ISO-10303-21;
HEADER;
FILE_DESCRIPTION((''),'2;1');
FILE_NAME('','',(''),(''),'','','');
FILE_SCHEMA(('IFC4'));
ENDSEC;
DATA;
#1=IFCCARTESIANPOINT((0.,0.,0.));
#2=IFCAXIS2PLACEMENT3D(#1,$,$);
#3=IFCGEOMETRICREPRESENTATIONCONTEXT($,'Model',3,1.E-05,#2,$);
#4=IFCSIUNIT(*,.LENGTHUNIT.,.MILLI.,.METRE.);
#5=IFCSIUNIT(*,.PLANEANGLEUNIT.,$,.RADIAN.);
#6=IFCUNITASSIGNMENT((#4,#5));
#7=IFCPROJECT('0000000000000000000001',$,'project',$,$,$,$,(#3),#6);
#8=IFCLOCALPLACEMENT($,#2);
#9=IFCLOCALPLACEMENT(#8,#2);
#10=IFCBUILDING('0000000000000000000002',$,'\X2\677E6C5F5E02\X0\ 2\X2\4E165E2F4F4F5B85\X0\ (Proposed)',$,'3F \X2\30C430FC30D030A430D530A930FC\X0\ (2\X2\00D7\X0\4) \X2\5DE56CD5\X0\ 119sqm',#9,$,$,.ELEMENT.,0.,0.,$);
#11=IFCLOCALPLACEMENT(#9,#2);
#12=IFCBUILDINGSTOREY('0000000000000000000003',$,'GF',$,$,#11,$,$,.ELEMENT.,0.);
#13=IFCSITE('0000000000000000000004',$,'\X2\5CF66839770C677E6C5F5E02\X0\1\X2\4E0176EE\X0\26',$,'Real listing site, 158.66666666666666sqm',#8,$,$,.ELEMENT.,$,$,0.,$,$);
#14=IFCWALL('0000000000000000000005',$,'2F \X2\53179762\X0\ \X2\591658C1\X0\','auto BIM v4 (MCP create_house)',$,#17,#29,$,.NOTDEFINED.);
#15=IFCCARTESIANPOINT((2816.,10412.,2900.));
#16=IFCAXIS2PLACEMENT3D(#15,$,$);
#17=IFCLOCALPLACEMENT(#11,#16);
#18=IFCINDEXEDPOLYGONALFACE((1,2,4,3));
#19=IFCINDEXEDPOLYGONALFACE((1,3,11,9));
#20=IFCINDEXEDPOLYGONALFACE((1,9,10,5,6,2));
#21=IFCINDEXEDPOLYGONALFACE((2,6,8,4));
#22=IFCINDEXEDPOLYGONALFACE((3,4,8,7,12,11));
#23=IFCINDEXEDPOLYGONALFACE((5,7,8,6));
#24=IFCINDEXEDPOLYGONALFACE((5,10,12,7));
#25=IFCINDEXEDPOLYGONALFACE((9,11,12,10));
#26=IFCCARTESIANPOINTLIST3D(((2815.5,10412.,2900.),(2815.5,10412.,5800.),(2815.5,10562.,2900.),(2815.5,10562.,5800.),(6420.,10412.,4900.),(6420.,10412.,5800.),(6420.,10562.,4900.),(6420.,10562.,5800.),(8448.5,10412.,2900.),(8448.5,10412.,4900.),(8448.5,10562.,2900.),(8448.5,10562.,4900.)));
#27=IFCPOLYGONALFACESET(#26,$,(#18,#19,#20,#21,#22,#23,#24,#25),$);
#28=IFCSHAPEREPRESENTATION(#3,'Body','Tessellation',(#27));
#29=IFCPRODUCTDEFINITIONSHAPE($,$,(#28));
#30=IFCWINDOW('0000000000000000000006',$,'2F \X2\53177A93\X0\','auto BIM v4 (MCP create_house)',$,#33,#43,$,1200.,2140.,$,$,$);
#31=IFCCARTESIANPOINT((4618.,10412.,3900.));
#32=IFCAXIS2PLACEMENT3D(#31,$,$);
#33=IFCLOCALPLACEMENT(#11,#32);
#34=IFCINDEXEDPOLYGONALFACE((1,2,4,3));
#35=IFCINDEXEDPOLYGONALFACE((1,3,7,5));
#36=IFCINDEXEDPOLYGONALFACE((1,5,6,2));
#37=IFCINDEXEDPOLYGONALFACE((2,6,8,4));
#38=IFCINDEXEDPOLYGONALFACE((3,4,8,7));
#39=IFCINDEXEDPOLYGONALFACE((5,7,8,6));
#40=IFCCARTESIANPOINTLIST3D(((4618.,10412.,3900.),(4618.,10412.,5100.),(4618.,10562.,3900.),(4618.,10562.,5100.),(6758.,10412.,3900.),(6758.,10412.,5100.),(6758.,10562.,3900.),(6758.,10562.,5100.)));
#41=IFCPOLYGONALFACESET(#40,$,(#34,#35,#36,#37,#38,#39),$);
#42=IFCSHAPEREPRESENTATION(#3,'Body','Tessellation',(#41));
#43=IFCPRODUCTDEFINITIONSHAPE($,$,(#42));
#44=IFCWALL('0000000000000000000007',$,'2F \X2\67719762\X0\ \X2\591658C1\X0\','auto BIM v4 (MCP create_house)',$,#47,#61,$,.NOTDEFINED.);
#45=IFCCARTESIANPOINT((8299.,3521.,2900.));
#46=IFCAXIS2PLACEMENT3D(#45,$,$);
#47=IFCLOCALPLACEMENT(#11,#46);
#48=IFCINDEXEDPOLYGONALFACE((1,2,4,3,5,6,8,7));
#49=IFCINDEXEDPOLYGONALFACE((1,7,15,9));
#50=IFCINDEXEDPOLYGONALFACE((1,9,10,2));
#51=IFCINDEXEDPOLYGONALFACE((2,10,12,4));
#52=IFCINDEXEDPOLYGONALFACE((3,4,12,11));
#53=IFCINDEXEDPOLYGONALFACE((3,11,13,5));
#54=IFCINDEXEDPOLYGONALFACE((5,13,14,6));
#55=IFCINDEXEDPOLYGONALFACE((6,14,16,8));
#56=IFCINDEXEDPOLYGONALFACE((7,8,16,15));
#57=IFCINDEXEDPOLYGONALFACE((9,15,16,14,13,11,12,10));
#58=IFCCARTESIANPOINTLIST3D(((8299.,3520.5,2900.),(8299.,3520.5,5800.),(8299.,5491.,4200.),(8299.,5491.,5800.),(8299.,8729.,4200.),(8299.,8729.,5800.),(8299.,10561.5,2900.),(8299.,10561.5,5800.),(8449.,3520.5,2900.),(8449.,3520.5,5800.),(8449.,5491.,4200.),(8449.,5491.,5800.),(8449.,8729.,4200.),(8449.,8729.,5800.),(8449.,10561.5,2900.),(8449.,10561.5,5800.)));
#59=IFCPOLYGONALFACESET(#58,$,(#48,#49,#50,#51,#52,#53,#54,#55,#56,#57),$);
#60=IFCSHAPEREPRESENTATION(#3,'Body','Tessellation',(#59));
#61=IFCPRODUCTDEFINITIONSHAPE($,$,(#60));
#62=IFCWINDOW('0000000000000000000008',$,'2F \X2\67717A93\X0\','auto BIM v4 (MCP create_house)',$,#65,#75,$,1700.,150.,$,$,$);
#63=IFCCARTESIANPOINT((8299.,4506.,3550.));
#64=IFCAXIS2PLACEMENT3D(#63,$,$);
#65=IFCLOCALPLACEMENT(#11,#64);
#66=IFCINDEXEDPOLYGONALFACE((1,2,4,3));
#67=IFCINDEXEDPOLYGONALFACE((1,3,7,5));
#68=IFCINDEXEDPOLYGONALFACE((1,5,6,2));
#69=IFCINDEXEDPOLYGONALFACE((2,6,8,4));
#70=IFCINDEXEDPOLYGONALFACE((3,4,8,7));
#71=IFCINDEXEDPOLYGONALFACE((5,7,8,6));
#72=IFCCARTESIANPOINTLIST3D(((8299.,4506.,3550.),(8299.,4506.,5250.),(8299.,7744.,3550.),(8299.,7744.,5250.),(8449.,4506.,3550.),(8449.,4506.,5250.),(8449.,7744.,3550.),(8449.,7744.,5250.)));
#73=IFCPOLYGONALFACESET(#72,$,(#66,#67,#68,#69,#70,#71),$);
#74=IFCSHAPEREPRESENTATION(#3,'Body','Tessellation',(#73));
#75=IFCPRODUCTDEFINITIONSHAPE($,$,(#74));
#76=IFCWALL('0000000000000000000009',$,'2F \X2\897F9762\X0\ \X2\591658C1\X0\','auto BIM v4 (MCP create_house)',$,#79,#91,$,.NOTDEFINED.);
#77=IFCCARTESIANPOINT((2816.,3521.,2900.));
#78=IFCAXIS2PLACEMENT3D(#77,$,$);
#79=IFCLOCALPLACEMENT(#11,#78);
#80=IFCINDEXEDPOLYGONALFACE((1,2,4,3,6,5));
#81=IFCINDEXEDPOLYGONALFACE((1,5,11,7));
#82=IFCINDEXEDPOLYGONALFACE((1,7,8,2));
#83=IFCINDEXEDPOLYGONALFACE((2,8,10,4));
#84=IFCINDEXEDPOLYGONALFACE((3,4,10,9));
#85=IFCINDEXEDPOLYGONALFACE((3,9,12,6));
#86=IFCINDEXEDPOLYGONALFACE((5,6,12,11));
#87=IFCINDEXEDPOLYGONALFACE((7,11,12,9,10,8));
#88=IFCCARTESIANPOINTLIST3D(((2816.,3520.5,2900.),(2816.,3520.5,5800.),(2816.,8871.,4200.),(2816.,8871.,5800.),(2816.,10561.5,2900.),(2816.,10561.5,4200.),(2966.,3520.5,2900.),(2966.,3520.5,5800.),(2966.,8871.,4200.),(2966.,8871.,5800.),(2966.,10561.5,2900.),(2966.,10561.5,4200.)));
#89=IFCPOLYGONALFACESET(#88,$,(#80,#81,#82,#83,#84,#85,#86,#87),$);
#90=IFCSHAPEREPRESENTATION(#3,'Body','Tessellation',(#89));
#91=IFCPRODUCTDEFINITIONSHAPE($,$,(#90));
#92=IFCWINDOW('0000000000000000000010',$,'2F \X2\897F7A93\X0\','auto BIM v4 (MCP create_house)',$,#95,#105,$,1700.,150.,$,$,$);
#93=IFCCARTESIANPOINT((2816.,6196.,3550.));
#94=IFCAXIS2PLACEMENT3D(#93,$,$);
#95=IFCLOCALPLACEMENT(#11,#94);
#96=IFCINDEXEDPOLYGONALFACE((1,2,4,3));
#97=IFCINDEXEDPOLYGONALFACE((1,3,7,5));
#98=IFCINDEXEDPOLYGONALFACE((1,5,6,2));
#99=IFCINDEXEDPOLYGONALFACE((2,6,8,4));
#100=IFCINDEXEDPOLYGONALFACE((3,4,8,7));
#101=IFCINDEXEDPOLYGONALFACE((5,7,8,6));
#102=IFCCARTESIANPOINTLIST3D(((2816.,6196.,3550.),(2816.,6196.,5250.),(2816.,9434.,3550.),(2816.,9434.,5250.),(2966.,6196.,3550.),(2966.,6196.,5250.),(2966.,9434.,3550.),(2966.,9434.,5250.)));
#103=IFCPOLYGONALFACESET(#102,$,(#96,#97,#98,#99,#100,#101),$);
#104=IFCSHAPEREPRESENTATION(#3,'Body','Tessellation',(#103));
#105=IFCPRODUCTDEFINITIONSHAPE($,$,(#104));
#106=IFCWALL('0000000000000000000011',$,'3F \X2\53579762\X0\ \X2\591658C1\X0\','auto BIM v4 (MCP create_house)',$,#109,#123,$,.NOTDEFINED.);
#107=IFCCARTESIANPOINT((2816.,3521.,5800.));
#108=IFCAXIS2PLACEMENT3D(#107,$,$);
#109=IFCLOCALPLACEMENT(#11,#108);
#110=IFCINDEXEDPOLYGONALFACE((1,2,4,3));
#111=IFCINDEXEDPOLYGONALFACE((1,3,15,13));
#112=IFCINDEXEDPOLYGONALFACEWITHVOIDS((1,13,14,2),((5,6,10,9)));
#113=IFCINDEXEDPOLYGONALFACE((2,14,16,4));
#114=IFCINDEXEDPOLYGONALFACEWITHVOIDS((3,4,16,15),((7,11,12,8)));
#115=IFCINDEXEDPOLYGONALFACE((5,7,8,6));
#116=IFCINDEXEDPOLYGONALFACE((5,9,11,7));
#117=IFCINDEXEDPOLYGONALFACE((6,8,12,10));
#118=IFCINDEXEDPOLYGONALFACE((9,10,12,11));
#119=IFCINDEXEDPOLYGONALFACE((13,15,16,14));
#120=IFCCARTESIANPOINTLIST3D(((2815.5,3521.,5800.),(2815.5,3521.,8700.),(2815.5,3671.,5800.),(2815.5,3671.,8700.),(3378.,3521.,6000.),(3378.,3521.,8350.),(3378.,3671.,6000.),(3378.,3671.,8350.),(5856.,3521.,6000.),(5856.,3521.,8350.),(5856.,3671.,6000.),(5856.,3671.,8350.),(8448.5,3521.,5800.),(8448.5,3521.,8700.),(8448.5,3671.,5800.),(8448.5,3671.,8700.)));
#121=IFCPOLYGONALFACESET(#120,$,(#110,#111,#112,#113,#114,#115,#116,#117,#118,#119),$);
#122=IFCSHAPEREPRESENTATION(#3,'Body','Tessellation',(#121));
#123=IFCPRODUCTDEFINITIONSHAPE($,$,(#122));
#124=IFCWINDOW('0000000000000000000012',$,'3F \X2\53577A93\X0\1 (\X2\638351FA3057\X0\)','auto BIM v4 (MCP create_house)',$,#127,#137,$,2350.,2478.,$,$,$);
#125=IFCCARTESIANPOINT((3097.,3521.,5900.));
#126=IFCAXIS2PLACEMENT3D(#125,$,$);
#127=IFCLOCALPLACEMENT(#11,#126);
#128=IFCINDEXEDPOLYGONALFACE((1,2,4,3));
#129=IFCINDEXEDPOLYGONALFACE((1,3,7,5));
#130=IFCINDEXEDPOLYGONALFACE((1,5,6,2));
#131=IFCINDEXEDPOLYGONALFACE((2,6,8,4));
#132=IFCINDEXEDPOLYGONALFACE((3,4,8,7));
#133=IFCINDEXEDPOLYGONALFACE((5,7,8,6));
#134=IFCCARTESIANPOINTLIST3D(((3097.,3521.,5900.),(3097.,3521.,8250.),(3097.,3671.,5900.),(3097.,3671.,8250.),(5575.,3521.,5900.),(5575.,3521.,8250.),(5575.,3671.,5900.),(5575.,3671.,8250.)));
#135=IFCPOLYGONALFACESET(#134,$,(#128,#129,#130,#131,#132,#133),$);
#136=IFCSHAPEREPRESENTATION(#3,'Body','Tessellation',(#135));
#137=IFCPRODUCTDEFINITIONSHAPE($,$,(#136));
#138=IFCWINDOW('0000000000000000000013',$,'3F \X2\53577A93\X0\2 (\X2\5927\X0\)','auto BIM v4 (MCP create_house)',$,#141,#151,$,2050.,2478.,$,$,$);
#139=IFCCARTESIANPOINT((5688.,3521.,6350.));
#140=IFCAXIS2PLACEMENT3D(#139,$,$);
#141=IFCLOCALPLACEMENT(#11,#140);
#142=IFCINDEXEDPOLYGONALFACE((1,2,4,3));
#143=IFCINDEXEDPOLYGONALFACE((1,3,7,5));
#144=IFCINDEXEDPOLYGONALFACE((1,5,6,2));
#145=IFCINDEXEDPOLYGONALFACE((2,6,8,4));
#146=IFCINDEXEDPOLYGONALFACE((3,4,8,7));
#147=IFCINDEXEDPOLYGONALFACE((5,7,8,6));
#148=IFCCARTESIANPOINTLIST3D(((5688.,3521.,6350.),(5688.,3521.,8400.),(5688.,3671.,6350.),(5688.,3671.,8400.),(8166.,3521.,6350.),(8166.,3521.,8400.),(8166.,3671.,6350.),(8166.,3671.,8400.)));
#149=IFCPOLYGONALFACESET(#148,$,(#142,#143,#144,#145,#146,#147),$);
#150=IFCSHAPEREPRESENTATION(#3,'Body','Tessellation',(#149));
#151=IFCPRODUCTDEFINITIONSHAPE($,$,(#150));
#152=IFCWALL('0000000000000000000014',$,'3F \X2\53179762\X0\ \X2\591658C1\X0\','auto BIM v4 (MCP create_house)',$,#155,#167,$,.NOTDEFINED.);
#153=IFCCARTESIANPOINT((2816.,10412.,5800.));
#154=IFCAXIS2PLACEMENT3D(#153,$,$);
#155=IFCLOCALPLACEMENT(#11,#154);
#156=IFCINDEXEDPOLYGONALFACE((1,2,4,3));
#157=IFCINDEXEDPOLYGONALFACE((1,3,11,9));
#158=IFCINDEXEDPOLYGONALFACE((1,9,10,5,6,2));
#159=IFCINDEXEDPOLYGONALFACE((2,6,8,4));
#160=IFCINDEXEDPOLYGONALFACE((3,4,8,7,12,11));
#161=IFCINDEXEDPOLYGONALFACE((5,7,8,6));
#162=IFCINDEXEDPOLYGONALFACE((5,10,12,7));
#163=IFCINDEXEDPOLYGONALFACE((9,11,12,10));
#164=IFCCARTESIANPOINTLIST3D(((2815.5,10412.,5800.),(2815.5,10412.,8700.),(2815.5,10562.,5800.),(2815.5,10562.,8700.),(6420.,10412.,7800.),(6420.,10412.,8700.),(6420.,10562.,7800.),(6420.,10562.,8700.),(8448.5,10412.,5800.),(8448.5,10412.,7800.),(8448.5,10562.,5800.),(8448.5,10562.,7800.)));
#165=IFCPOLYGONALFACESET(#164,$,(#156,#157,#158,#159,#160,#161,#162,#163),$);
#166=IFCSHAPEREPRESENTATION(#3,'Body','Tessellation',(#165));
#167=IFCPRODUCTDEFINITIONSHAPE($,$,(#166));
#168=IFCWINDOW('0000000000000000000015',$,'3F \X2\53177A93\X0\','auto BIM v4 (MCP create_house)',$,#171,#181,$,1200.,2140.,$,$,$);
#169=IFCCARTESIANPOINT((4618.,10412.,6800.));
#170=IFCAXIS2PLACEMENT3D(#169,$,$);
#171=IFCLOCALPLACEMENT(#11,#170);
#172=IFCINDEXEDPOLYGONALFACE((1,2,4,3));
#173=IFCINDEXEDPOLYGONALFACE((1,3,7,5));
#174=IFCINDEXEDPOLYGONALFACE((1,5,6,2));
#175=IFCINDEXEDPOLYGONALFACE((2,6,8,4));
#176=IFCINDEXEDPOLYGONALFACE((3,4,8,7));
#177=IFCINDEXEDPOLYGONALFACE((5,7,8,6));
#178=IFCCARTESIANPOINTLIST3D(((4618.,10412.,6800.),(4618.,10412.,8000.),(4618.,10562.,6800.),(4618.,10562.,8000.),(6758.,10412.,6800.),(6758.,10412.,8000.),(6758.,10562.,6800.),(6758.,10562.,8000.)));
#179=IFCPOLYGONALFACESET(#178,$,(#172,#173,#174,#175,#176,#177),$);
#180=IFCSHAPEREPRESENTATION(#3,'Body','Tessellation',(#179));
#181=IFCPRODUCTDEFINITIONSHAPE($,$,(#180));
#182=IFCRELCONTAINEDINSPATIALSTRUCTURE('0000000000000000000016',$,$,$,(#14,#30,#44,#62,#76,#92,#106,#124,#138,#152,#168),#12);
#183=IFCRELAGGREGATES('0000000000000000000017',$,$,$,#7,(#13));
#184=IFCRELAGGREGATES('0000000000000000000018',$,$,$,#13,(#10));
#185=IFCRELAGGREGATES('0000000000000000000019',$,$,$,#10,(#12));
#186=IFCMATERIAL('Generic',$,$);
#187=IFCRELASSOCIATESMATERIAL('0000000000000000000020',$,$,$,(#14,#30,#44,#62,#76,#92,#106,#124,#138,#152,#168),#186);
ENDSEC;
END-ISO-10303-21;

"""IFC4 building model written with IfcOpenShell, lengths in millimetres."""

from ifc_helpers import new_model, si_unit, frame, frame_2d, origin, place, context, project, spatial, rectangle, extrude, material, element, fill, save


model = new_model("IFC4")

# Units and contexts
model_context = context("Model", 3, precision=1e-05, world=origin())
ifc_project = project(units=[si_unit("LENGTHUNIT", "METRE", prefix="MILLI"), si_unit("PLANEANGLEUNIT", "RADIAN")], contexts=[model_context])

# Site, building, storey
site_placement = place(None, origin())
site = spatial("IfcSite", under=ifc_project, at=site_placement, Name="島根県松江市1丁目26", ObjectType="Real listing site, 158.66666666666666sqm", CompositionType="ELEMENT", RefElevation=0.0)
building_placement = place(site_placement, origin())
building = spatial("IfcBuilding", under=site, at=building_placement, Name="松江市 2世帯住宅 (Proposed)", ObjectType="3F ツーバイフォー (2×4) 工法 119sqm", CompositionType="ELEMENT", ElevationOfRefHeight=0.0, ElevationOfTerrain=0.0)
storey_placement = place(building_placement, origin())
storey = spatial("IfcBuildingStorey", under=building, at=storey_placement, Name="GF", CompositionType="ELEMENT", Elevation=0.0)

# Shared definitions
ifc_material = material(Name="Generic")

# Walls, openings, windows
wall_1_placement = place(storey_placement, frame((2816.0, 10412.0, 2900.0)))
wall_1 = element("IfcWall", 1, at=wall_1_placement, inside=storey, material=ifc_material, Name="2F 北面 外壁", Description="auto BIM v4 (MCP create_house)", PredefinedType="NOTDEFINED", context=model_context, shape_type="SweptSolid", body=[
    extrude(rectangle(XDim=5633.0, YDim=150.0, at=frame_2d((2816.0, 75.0))), frame((2816.0, 10412.0, 2900.0)), (0.0, 0.0, 1.0), 2900.0),
])
opening_1_placement = place(storey_placement, frame((4618.0, 10412.0, 3900.0)))
opening_1 = element("IfcOpeningElement", 2, at=opening_1_placement, cuts=wall_1, PredefinedType="NOTDEFINED", context=model_context, shape_type="SweptSolid", body=[
    extrude(rectangle(XDim=2140.0, YDim=150.0, at=frame_2d((1070.0, 75.0))), frame((4618.0, 10412.0, 3900.0)), (0.0, 0.0, 1.0), 1200.0),
])
window_1_placement = place(storey_placement, frame((4618.0, 10412.0, 3900.0)))
window_1 = element("IfcWindow", 3, at=window_1_placement, inside=storey, material=ifc_material, Name="2F 北窓", Description="auto BIM v4 (MCP create_house)", OverallHeight=1200.0, OverallWidth=2140.0, context=model_context, shape_type="SweptSolid", body=[
    extrude(rectangle(XDim=2140.0, YDim=150.0, at=frame_2d((1070.0, 75.0))), frame((4618.0, 10412.0, 3900.0)), (0.0, 0.0, 1.0), 1200.0),
])
fill(opening_1, window_1)
wall_2_placement = place(storey_placement, frame((8299.0, 3521.0, 2900.0)))
wall_2 = element("IfcWall", 4, at=wall_2_placement, inside=storey, material=ifc_material, Name="2F 東面 外壁", Description="auto BIM v4 (MCP create_house)", PredefinedType="NOTDEFINED", context=model_context, shape_type="SweptSolid", body=[
    extrude(rectangle(XDim=150.0, YDim=7041.0, at=frame_2d((75.0, 3520.0))), frame((8299.0, 3521.0, 2900.0)), (0.0, 0.0, 1.0), 2900.0),
])
opening_2_placement = place(storey_placement, frame((8299.0, 4506.0, 3550.0)))
opening_2 = element("IfcOpeningElement", 5, at=opening_2_placement, cuts=wall_2, PredefinedType="NOTDEFINED", context=model_context, shape_type="SweptSolid", body=[
    extrude(rectangle(XDim=150.0, YDim=3238.0, at=frame_2d((75.0, 1619.0))), frame((8299.0, 4506.0, 3550.0)), (0.0, 0.0, 1.0), 1700.0),
])
window_2_placement = place(storey_placement, frame((8299.0, 4506.0, 3550.0)))
window_2 = element("IfcWindow", 6, at=window_2_placement, inside=storey, material=ifc_material, Name="2F 東窓", Description="auto BIM v4 (MCP create_house)", OverallHeight=1700.0, OverallWidth=150.0, context=model_context, shape_type="SweptSolid", body=[
    extrude(rectangle(XDim=150.0, YDim=3238.0, at=frame_2d((75.0, 1619.0))), frame((8299.0, 4506.0, 3550.0)), (0.0, 0.0, 1.0), 1700.0),
])
fill(opening_2, window_2)
wall_3_placement = place(storey_placement, frame((2816.0, 3521.0, 2900.0)))
wall_3 = element("IfcWall", 7, at=wall_3_placement, inside=storey, material=ifc_material, Name="2F 西面 外壁", Description="auto BIM v4 (MCP create_house)", PredefinedType="NOTDEFINED", context=model_context, shape_type="SweptSolid", body=[
    extrude(rectangle(XDim=150.0, YDim=7041.0, at=frame_2d((75.0, 3520.0))), frame((2816.0, 3521.0, 2900.0)), (0.0, 0.0, 1.0), 2900.0),
])
opening_3_placement = place(storey_placement, frame((2816.0, 6196.0, 3550.0)))
opening_3 = element("IfcOpeningElement", 8, at=opening_3_placement, cuts=wall_3, PredefinedType="NOTDEFINED", context=model_context, shape_type="SweptSolid", body=[
    extrude(rectangle(XDim=150.0, YDim=3238.0, at=frame_2d((75.0, 1619.0))), frame((2816.0, 6196.0, 3550.0)), (0.0, 0.0, 1.0), 1700.0),
])
window_3_placement = place(storey_placement, frame((2816.0, 6196.0, 3550.0)))
window_3 = element("IfcWindow", 9, at=window_3_placement, inside=storey, material=ifc_material, Name="2F 西窓", Description="auto BIM v4 (MCP create_house)", OverallHeight=1700.0, OverallWidth=150.0, context=model_context, shape_type="SweptSolid", body=[
    extrude(rectangle(XDim=150.0, YDim=3238.0, at=frame_2d((75.0, 1619.0))), frame((2816.0, 6196.0, 3550.0)), (0.0, 0.0, 1.0), 1700.0),
])
fill(opening_3, window_3)

# Wall, openings, windows
wall_4_placement = place(storey_placement, frame((2816.0, 3521.0, 5800.0)))
wall_4 = element("IfcWall", 10, at=wall_4_placement, inside=storey, material=ifc_material, Name="3F 南面 外壁", Description="auto BIM v4 (MCP create_house)", PredefinedType="NOTDEFINED", context=model_context, shape_type="SweptSolid", body=[
    extrude(rectangle(XDim=5633.0, YDim=150.0, at=frame_2d((2816.0, 75.0))), frame((2816.0, 3521.0, 5800.0)), (0.0, 0.0, 1.0), 2900.0),
])
opening_4_placement = place(storey_placement, frame((3097.0, 3521.0, 5900.0)))
opening_4 = element("IfcOpeningElement", 11, at=opening_4_placement, cuts=wall_4, PredefinedType="NOTDEFINED", context=model_context, shape_type="SweptSolid", body=[
    extrude(rectangle(XDim=2478.0, YDim=150.0, at=frame_2d((1239.0, 75.0))), frame((3097.0, 3521.0, 5900.0)), (0.0, 0.0, 1.0), 2350.0),
])
opening_5_placement = place(storey_placement, frame((5688.0, 3521.0, 6350.0)))
opening_5 = element("IfcOpeningElement", 12, at=opening_5_placement, cuts=wall_4, PredefinedType="NOTDEFINED", context=model_context, shape_type="SweptSolid", body=[
    extrude(rectangle(XDim=2478.0, YDim=150.0, at=frame_2d((1239.0, 75.0))), frame((5688.0, 3521.0, 6350.0)), (0.0, 0.0, 1.0), 2050.0),
])
window_4_placement = place(storey_placement, frame((3097.0, 3521.0, 5900.0)))
window_4 = element("IfcWindow", 13, at=window_4_placement, inside=storey, material=ifc_material, Name="3F 南窓1 (掃出し)", Description="auto BIM v4 (MCP create_house)", OverallHeight=2350.0, OverallWidth=2478.0, context=model_context, shape_type="SweptSolid", body=[
    extrude(rectangle(XDim=2478.0, YDim=150.0, at=frame_2d((1239.0, 75.0))), frame((3097.0, 3521.0, 5900.0)), (0.0, 0.0, 1.0), 2350.0),
])
fill(opening_4, window_4)
window_5_placement = place(storey_placement, frame((5688.0, 3521.0, 6350.0)))
window_5 = element("IfcWindow", 14, at=window_5_placement, inside=storey, material=ifc_material, Name="3F 南窓2 (大)", Description="auto BIM v4 (MCP create_house)", OverallHeight=2050.0, OverallWidth=2478.0, context=model_context, shape_type="SweptSolid", body=[
    extrude(rectangle(XDim=2478.0, YDim=150.0, at=frame_2d((1239.0, 75.0))), frame((5688.0, 3521.0, 6350.0)), (0.0, 0.0, 1.0), 2050.0),
])
fill(opening_5, window_5)

# Wall, opening, window
wall_5_placement = place(storey_placement, frame((2816.0, 10412.0, 5800.0)))
wall_5 = element("IfcWall", 15, at=wall_5_placement, inside=storey, material=ifc_material, Name="3F 北面 外壁", Description="auto BIM v4 (MCP create_house)", PredefinedType="NOTDEFINED", context=model_context, shape_type="SweptSolid", body=[
    extrude(rectangle(XDim=5633.0, YDim=150.0, at=frame_2d((2816.0, 75.0))), frame((2816.0, 10412.0, 5800.0)), (0.0, 0.0, 1.0), 2900.0),
])
opening_6_placement = place(storey_placement, frame((4618.0, 10412.0, 6800.0)))
opening_6 = element("IfcOpeningElement", 16, at=opening_6_placement, cuts=wall_5, PredefinedType="NOTDEFINED", context=model_context, shape_type="SweptSolid", body=[
    extrude(rectangle(XDim=2140.0, YDim=150.0, at=frame_2d((1070.0, 75.0))), frame((4618.0, 10412.0, 6800.0)), (0.0, 0.0, 1.0), 1200.0),
])
window_6_placement = place(storey_placement, frame((4618.0, 10412.0, 6800.0)))
window_6 = element("IfcWindow", 17, at=window_6_placement, inside=storey, material=ifc_material, Name="3F 北窓", Description="auto BIM v4 (MCP create_house)", OverallHeight=1200.0, OverallWidth=2140.0, context=model_context, shape_type="SweptSolid", body=[
    extrude(rectangle(XDim=2140.0, YDim=150.0, at=frame_2d((1070.0, 75.0))), frame((4618.0, 10412.0, 6800.0)), (0.0, 0.0, 1.0), 1200.0),
])
fill(opening_6, window_6)

save(model, "model.ifc")
